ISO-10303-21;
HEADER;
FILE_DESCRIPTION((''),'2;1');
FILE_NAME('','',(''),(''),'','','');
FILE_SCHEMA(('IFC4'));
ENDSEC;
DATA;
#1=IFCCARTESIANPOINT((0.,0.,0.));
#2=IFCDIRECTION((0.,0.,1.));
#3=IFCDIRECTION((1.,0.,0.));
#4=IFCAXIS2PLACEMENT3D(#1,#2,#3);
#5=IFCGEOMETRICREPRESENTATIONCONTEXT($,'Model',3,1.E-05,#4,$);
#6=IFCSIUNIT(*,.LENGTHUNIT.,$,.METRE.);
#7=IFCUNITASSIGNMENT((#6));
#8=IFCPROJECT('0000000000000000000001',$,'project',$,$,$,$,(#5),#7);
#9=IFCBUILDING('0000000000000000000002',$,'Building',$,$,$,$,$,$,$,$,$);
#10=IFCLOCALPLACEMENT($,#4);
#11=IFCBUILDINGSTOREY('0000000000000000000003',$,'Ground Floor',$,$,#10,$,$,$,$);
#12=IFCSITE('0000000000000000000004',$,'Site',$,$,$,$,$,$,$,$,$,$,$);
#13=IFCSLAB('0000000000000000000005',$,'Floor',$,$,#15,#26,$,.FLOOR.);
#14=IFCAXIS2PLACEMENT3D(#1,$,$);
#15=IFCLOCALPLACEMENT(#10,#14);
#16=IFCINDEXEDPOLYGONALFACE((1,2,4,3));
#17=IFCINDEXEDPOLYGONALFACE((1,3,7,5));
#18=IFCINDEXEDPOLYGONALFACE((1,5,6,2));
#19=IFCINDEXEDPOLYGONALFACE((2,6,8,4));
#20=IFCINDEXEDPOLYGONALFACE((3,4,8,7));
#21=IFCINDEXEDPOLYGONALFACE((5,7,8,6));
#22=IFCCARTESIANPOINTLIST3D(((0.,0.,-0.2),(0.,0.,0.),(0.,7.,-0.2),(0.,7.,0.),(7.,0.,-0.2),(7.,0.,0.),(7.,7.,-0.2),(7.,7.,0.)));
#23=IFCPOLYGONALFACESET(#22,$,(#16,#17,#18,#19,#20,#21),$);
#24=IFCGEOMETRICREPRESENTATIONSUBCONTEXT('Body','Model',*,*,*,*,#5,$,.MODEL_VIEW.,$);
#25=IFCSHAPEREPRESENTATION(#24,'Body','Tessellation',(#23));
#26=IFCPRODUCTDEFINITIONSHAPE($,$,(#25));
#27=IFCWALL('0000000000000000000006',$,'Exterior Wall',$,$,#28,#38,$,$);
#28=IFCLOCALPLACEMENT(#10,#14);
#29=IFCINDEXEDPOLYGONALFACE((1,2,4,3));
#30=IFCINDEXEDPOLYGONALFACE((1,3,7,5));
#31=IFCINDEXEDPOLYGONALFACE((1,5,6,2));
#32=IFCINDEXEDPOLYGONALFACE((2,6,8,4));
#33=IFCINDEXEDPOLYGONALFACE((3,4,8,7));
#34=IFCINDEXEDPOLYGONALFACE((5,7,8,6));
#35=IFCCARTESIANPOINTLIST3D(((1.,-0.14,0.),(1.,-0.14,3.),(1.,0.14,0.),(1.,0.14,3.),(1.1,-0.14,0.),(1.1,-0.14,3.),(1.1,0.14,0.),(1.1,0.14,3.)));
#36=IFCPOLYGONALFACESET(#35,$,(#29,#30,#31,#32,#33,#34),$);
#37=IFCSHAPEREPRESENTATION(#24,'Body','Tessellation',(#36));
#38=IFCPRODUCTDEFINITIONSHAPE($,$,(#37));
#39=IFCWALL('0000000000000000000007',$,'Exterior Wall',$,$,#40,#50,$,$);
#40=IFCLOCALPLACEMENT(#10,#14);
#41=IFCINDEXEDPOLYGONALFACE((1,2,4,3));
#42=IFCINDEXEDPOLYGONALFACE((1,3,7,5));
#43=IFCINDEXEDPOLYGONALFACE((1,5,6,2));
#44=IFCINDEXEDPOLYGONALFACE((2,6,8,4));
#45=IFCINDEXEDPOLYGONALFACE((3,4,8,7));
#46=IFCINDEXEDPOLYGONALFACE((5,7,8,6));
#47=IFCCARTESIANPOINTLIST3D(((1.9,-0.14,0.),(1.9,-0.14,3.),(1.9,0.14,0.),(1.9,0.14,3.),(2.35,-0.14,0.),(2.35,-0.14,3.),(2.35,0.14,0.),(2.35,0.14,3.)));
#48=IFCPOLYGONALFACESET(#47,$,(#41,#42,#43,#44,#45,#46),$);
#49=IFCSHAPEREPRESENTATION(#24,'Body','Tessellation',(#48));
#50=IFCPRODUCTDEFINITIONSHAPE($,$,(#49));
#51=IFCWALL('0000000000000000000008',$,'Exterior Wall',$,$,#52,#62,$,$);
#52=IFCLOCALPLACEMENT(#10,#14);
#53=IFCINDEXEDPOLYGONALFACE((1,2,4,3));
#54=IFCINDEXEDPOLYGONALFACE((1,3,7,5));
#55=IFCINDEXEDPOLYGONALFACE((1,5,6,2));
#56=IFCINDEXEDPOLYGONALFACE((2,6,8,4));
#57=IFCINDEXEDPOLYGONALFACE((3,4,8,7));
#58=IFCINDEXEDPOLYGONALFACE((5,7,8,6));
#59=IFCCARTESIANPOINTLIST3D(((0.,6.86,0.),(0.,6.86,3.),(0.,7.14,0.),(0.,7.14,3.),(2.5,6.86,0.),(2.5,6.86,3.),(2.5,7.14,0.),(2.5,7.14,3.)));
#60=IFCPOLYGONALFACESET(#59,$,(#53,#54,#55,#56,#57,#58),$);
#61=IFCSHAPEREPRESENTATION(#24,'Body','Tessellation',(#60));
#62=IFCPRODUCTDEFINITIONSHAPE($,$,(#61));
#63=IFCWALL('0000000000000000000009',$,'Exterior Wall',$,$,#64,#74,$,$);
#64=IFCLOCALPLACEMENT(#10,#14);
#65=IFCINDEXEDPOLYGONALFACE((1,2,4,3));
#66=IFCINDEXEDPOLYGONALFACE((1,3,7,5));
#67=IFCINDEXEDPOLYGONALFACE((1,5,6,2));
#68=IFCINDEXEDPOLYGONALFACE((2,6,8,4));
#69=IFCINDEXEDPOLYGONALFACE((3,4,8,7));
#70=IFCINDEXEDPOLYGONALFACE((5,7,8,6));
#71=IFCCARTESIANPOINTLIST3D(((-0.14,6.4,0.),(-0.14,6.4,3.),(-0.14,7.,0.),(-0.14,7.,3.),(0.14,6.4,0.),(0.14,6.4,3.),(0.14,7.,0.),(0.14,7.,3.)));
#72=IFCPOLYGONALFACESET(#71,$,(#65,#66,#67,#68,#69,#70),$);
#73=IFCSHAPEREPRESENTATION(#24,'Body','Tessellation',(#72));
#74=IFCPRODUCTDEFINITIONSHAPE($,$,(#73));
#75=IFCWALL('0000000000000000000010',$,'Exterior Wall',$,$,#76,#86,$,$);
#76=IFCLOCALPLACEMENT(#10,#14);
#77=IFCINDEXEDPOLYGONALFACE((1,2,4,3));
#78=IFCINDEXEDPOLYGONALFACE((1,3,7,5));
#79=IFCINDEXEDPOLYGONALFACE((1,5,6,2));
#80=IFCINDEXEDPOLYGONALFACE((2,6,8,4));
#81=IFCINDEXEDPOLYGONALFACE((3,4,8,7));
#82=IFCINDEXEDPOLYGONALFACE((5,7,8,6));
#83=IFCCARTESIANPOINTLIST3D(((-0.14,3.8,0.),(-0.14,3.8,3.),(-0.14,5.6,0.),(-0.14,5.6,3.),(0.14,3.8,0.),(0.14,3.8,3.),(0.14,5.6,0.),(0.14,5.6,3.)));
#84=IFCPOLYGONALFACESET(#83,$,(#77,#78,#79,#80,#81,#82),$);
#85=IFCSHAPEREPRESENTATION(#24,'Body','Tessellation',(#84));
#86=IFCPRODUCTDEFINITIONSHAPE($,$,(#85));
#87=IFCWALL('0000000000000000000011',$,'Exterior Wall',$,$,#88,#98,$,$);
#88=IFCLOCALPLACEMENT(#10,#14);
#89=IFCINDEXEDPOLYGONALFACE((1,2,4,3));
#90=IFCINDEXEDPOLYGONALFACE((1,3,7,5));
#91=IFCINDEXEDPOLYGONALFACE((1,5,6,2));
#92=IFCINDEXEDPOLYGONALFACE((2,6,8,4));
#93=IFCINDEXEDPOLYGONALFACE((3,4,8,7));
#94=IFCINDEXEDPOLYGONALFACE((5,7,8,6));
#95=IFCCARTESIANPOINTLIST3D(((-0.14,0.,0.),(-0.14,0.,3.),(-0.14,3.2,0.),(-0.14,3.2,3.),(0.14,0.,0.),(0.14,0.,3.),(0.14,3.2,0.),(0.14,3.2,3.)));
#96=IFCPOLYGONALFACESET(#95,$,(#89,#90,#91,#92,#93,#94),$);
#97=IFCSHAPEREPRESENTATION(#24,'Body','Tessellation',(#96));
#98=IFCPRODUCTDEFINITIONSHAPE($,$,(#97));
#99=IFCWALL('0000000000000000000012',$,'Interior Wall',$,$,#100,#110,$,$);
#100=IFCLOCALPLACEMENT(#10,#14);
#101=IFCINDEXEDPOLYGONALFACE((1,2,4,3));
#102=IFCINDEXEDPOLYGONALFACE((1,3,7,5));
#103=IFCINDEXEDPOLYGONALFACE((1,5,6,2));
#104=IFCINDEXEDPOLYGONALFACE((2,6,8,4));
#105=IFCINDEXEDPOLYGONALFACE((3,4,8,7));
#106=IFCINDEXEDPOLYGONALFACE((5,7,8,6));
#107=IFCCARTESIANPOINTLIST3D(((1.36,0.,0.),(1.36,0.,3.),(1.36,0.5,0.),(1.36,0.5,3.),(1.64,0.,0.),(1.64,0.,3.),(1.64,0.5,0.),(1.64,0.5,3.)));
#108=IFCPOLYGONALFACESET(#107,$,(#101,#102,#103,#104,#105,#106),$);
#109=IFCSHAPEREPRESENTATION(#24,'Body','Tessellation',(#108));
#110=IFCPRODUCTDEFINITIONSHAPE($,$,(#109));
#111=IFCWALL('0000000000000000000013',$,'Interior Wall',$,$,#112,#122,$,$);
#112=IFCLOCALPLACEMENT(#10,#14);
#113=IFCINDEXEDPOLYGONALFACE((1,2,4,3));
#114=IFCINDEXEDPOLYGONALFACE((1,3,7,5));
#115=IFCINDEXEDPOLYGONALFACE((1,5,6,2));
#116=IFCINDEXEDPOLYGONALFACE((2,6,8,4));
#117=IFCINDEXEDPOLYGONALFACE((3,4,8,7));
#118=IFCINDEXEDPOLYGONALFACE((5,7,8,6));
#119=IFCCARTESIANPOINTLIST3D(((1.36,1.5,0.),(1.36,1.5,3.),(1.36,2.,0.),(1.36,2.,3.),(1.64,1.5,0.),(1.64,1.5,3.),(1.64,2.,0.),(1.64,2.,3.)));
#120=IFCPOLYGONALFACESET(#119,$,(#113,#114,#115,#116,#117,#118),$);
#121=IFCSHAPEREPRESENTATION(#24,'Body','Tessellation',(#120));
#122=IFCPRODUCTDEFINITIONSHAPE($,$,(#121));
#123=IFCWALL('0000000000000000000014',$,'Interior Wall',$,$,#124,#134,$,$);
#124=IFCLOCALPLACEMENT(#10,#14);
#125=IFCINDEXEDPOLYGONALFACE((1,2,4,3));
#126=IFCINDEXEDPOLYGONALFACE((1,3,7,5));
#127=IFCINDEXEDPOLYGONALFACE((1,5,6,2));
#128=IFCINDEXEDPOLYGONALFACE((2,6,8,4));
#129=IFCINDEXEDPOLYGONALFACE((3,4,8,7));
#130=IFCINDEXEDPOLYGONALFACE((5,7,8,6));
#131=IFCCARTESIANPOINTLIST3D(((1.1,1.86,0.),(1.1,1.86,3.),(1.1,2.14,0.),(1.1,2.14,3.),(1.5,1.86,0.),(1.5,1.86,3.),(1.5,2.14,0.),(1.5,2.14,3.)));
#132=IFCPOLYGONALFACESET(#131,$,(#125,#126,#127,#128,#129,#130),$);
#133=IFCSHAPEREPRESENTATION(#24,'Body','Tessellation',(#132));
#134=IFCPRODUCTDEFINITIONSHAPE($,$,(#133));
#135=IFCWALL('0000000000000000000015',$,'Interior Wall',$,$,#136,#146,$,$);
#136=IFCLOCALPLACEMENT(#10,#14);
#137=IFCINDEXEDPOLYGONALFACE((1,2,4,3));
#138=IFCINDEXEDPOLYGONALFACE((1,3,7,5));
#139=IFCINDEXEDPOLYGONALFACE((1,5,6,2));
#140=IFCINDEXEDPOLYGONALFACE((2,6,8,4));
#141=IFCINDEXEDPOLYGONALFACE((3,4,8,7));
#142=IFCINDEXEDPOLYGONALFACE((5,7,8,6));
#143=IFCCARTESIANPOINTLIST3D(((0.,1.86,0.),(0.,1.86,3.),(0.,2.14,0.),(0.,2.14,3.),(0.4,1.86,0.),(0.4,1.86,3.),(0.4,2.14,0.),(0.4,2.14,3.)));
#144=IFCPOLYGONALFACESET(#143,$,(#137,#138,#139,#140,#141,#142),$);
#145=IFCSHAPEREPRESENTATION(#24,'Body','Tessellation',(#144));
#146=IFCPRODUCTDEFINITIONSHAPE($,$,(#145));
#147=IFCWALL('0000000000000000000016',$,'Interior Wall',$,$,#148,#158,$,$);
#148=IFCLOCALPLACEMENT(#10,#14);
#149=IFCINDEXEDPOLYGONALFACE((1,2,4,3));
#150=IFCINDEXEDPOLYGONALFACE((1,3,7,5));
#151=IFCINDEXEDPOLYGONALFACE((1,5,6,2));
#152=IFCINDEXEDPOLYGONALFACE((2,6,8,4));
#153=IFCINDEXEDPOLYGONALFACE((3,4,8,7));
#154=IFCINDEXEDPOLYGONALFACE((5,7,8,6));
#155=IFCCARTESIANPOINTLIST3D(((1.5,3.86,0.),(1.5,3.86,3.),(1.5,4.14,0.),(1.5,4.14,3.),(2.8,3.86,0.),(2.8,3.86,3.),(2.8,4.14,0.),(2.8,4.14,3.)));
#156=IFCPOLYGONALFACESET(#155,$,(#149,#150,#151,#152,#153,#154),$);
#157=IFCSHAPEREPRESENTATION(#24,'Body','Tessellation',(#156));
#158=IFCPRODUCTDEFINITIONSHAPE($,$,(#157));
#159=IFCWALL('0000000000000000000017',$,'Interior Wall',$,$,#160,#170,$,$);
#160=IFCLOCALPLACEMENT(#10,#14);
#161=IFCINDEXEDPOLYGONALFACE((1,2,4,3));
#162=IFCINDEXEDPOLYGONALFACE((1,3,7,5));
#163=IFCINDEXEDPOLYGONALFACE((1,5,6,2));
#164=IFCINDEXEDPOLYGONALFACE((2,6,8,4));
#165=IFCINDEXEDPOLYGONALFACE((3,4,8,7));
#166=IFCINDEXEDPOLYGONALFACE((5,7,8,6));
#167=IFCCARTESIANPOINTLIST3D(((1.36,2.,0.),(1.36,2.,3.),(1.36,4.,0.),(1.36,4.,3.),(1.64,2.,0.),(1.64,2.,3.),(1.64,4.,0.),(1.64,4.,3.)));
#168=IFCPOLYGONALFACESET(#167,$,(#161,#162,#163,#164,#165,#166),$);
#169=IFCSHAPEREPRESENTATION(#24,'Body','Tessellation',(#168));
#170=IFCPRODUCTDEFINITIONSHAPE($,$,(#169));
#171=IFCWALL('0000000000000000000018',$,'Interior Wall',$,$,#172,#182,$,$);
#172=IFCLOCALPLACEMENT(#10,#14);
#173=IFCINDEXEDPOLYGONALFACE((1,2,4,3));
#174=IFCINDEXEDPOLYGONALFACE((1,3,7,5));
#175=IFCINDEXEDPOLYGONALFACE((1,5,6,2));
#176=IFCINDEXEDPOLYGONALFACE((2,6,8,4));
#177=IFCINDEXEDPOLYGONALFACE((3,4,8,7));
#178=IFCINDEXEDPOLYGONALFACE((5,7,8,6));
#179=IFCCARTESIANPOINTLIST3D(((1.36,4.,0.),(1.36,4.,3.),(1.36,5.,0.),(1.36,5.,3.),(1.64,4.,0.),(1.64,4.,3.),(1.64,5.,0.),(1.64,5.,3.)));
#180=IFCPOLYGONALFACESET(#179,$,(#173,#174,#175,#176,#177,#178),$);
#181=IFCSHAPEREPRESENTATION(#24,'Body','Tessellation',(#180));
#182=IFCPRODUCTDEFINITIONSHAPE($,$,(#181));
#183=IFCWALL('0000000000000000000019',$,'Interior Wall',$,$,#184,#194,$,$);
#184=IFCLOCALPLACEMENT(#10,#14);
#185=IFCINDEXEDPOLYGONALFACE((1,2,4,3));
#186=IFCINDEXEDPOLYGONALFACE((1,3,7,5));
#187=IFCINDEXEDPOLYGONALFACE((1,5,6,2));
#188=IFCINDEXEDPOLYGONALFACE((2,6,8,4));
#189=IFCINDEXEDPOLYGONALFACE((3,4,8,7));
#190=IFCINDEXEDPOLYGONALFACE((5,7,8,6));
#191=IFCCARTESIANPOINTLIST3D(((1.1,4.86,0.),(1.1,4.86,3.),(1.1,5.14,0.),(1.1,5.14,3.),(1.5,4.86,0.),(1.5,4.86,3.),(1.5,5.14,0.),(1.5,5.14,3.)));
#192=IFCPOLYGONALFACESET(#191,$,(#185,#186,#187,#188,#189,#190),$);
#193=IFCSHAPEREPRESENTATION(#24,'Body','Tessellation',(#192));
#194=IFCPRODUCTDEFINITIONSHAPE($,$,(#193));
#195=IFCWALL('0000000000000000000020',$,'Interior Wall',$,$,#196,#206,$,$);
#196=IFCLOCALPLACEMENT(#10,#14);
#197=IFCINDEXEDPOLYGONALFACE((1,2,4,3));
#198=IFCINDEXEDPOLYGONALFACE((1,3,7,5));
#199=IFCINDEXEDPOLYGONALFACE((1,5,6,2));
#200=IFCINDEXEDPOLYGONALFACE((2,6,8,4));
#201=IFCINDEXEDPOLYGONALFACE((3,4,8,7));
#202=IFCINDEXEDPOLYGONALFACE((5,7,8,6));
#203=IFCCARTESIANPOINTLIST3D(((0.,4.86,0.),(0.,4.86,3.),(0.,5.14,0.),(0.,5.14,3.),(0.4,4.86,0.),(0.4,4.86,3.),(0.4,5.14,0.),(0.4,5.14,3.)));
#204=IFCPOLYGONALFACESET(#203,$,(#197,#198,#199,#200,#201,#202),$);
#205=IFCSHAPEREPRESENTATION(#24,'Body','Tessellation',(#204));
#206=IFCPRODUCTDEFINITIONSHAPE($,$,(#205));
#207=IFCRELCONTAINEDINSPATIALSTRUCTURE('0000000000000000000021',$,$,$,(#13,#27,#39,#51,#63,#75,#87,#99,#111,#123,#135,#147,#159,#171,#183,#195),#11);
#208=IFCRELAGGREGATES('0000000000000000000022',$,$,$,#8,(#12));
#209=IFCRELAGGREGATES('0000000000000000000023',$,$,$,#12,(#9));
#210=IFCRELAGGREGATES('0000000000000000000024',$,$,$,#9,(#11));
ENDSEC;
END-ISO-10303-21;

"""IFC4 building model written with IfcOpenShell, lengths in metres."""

from ifc_helpers import new_model, si_unit, frame, origin_with_axes, place, context, subcontext, project, spatial, indexed_curve, outline, extrude, element, save


model = new_model("IFC4")

# Units and contexts
model_context = context("Model", 3, precision=1e-05, world=origin_with_axes())
body_context = subcontext(model_context, "Body", "Model", "MODEL_VIEW")
ifc_project = project(units=[si_unit("LENGTHUNIT", "METRE")], contexts=[model_context])

# Site, building, storey
site = spatial("IfcSite", under=ifc_project, Name="Site")
building = spatial("IfcBuilding", under=site, Name="Building")
storey_placement = place(None, origin_with_axes())
storey = spatial("IfcBuildingStorey", under=building, at=storey_placement, Name="Ground Floor")

# Slab
slab_placement = place(storey_placement, frame((0.0, 0.0, -0.2), z_axis=(0.0, 0.0, 1.0), x_axis=(1.0, 0.0, 0.0)))
element("IfcSlab", 1, at=slab_placement, inside=storey, Name="Floor", PredefinedType="FLOOR", context=body_context, shape_type="SweptSolid", body=[
    extrude(outline(indexed_curve([(0.0, 0.0), (7.0, 0.0), (7.0, 7.0), (0.0, 7.0)])), None, (0.0, 0.0, 1.0), 0.2),
])

# Walls
wall_1_placement = place(storey_placement, frame((1.0, 0.0, 0.0), z_axis=(0.0, 0.0, 1.0), x_axis=(1.0, 0.0, 0.0)))
element("IfcWall", 2, at=wall_1_placement, inside=storey, Name="Exterior Wall", context=body_context, shape_type="SweptSolid", body=[
    extrude(outline(indexed_curve([(0.0, 0.0), (0.0, 0.28), (0.1, 0.28), (0.1, 0.0), (0.0, 0.0)], self_intersect=False)), frame((0.0, -0.14, 0.0), z_axis=(0.0, 0.0, 1.0), x_axis=(1.0, 0.0, 0.0)), (0.0, 0.0, 1.0), 3.0),
])
wall_2_placement = place(storey_placement, frame((1.9, 0.0, 0.0), z_axis=(0.0, 0.0, 1.0), x_axis=(1.0, 0.0, 0.0)))
element("IfcWall", 3, at=wall_2_placement, inside=storey, Name="Exterior Wall", context=body_context, shape_type="SweptSolid", body=[
    extrude(outline(indexed_curve([(0.0, 0.0), (0.0, 0.28), (0.45, 0.28), (0.45, 0.0), (0.0, 0.0)], self_intersect=False)), frame((0.0, -0.14, 0.0), z_axis=(0.0, 0.0, 1.0), x_axis=(1.0, 0.0, 0.0)), (0.0, 0.0, 1.0), 3.0),
])
wall_3_placement = place(storey_placement, frame((2.5, 7.0, 0.0), z_axis=(0.0, 0.0, 1.0), x_axis=(-1.0, 0.0, 0.0)))
element("IfcWall", 4, at=wall_3_placement, inside=storey, Name="Exterior Wall", context=body_context, shape_type="SweptSolid", body=[
    extrude(outline(indexed_curve([(0.0, 0.0), (0.0, 0.28), (2.5, 0.28), (2.5, 0.0), (0.0, 0.0)], self_intersect=False)), frame((0.0, -0.14, 0.0), z_axis=(0.0, 0.0, 1.0), x_axis=(1.0, 0.0, 0.0)), (0.0, 0.0, 1.0), 3.0),
])
wall_4_placement = place(storey_placement, frame((0.0, 7.0, 0.0), z_axis=(0.0, 0.0, 1.0), x_axis=(0.0, -1.0, 0.0)))
element("IfcWall", 5, at=wall_4_placement, inside=storey, Name="Exterior Wall", context=body_context, shape_type="SweptSolid", body=[
    extrude(outline(indexed_curve([(0.0, 0.0), (0.0, 0.28), (0.6, 0.28), (0.6, 0.0), (0.0, 0.0)], self_intersect=False)), frame((0.0, -0.14, 0.0), z_axis=(0.0, 0.0, 1.0), x_axis=(1.0, 0.0, 0.0)), (0.0, 0.0, 1.0), 3.0),
])
wall_5_placement = place(storey_placement, frame((0.0, 5.6, 0.0), z_axis=(0.0, 0.0, 1.0), x_axis=(0.0, -1.0, 0.0)))
element("IfcWall", 6, at=wall_5_placement, inside=storey, Name="Exterior Wall", context=body_context, shape_type="SweptSolid", body=[
    extrude(outline(indexed_curve([(0.0, 0.0), (0.0, 0.28), (1.8, 0.28), (1.8, 0.0), (0.0, 0.0)], self_intersect=False)), frame((0.0, -0.14, 0.0), z_axis=(0.0, 0.0, 1.0), x_axis=(1.0, 0.0, 0.0)), (0.0, 0.0, 1.0), 3.0),
])
wall_6_placement = place(storey_placement, frame((0.0, 3.2, 0.0), z_axis=(0.0, 0.0, 1.0), x_axis=(0.0, -1.0, 0.0)))
element("IfcWall", 7, at=wall_6_placement, inside=storey, Name="Exterior Wall", context=body_context, shape_type="SweptSolid", body=[
    extrude(outline(indexed_curve([(0.0, 0.0), (0.0, 0.28), (3.2, 0.28), (3.2, 0.0), (0.0, 0.0)], self_intersect=False)), frame((0.0, -0.14, 0.0), z_axis=(0.0, 0.0, 1.0), x_axis=(1.0, 0.0, 0.0)), (0.0, 0.0, 1.0), 3.0),
])
for number, where, z_axis, x_axis, name in (
    (8, (1.5, 0.0, 0.0), (0.0, 0.0, 1.0), (0.0, 1.0, 0.0), "Interior Wall"),
    (9, (1.5, 1.5, 0.0), (0.0, 0.0, 1.0), (0.0, 1.0, 0.0), "Interior Wall"),
):
    element("IfcWall", number, at=place(storey_placement, frame(where, z_axis=z_axis, x_axis=x_axis)), inside=storey, Name=name, context=body_context, shape_type="SweptSolid", body=[
        extrude(outline(indexed_curve([(0.0, 0.0), (0.0, 0.28), (0.5, 0.28), (0.5, 0.0), (0.0, 0.0)], self_intersect=False)), frame((0.0, -0.14, 0.0), z_axis=(0.0, 0.0, 1.0), x_axis=(1.0, 0.0, 0.0)), (0.0, 0.0, 1.0), 3.0),
    ])
for number, where, z_axis, x_axis, name in (
    (10, (1.5, 2.0, 0.0), (0.0, 0.0, 1.0), (-1.0, 0.0, 0.0), "Interior Wall"),
    (11, (0.4, 2.0, 0.0), (0.0, 0.0, 1.0), (-1.0, 0.0, 0.0), "Interior Wall"),
):
    element("IfcWall", number, at=place(storey_placement, frame(where, z_axis=z_axis, x_axis=x_axis)), inside=storey, Name=name, context=body_context, shape_type="SweptSolid", body=[
        extrude(outline(indexed_curve([(0.0, 0.0), (0.0, 0.28), (0.4, 0.28), (0.4, 0.0), (0.0, 0.0)], self_intersect=False)), frame((0.0, -0.14, 0.0), z_axis=(0.0, 0.0, 1.0), x_axis=(1.0, 0.0, 0.0)), (0.0, 0.0, 1.0), 3.0),
    ])
wall_7_placement = place(storey_placement, frame((2.8, 4.0, 0.0), z_axis=(0.0, 0.0, 1.0), x_axis=(-1.0, 0.0, 0.0)))
element("IfcWall", 12, at=wall_7_placement, inside=storey, Name="Interior Wall", context=body_context, shape_type="SweptSolid", body=[
    extrude(outline(indexed_curve([(0.0, 0.0), (0.0, 0.28), (1.3, 0.28), (1.3, 0.0), (0.0, 0.0)], self_intersect=False)), frame((0.0, -0.14, 0.0), z_axis=(0.0, 0.0, 1.0), x_axis=(1.0, 0.0, 0.0)), (0.0, 0.0, 1.0), 3.0),
])
wall_8_placement = place(storey_placement, frame((1.5, 4.0, 0.0), z_axis=(0.0, 0.0, 1.0), x_axis=(0.0, -1.0, 0.0)))
element("IfcWall", 13, at=wall_8_placement, inside=storey, Name="Interior Wall", context=body_context, shape_type="SweptSolid", body=[
    extrude(outline(indexed_curve([(0.0, 0.0), (0.0, 0.28), (2.0, 0.28), (2.0, 0.0), (0.0, 0.0)], self_intersect=False)), frame((0.0, -0.14, 0.0), z_axis=(0.0, 0.0, 1.0), x_axis=(1.0, 0.0, 0.0)), (0.0, 0.0, 1.0), 3.0),
])
wall_9_placement = place(storey_placement, frame((1.5, 4.0, 0.0), z_axis=(0.0, 0.0, 1.0), x_axis=(0.0, 1.0, 0.0)))
element("IfcWall", 14, at=wall_9_placement, inside=storey, Name="Interior Wall", context=body_context, shape_type="SweptSolid", body=[
    extrude(outline(indexed_curve([(0.0, 0.0), (0.0, 0.28), (1.0, 0.28), (1.0, 0.0), (0.0, 0.0)], self_intersect=False)), frame((0.0, -0.14, 0.0), z_axis=(0.0, 0.0, 1.0), x_axis=(1.0, 0.0, 0.0)), (0.0, 0.0, 1.0), 3.0),
])
for number, where, z_axis, x_axis, name in (
    (15, (1.5, 5.0, 0.0), (0.0, 0.0, 1.0), (-1.0, 0.0, 0.0), "Interior Wall"),
    (16, (0.4, 5.0, 0.0), (0.0, 0.0, 1.0), (-1.0, 0.0, 0.0), "Interior Wall"),
):
    element("IfcWall", number, at=place(storey_placement, frame(where, z_axis=z_axis, x_axis=x_axis)), inside=storey, Name=name, context=body_context, shape_type="SweptSolid", body=[
        extrude(outline(indexed_curve([(0.0, 0.0), (0.0, 0.28), (0.4, 0.28), (0.4, 0.0), (0.0, 0.0)], self_intersect=False)), frame((0.0, -0.14, 0.0), z_axis=(0.0, 0.0, 1.0), x_axis=(1.0, 0.0, 0.0)), (0.0, 0.0, 1.0), 3.0),
    ])

save(model, "model.ifc")
